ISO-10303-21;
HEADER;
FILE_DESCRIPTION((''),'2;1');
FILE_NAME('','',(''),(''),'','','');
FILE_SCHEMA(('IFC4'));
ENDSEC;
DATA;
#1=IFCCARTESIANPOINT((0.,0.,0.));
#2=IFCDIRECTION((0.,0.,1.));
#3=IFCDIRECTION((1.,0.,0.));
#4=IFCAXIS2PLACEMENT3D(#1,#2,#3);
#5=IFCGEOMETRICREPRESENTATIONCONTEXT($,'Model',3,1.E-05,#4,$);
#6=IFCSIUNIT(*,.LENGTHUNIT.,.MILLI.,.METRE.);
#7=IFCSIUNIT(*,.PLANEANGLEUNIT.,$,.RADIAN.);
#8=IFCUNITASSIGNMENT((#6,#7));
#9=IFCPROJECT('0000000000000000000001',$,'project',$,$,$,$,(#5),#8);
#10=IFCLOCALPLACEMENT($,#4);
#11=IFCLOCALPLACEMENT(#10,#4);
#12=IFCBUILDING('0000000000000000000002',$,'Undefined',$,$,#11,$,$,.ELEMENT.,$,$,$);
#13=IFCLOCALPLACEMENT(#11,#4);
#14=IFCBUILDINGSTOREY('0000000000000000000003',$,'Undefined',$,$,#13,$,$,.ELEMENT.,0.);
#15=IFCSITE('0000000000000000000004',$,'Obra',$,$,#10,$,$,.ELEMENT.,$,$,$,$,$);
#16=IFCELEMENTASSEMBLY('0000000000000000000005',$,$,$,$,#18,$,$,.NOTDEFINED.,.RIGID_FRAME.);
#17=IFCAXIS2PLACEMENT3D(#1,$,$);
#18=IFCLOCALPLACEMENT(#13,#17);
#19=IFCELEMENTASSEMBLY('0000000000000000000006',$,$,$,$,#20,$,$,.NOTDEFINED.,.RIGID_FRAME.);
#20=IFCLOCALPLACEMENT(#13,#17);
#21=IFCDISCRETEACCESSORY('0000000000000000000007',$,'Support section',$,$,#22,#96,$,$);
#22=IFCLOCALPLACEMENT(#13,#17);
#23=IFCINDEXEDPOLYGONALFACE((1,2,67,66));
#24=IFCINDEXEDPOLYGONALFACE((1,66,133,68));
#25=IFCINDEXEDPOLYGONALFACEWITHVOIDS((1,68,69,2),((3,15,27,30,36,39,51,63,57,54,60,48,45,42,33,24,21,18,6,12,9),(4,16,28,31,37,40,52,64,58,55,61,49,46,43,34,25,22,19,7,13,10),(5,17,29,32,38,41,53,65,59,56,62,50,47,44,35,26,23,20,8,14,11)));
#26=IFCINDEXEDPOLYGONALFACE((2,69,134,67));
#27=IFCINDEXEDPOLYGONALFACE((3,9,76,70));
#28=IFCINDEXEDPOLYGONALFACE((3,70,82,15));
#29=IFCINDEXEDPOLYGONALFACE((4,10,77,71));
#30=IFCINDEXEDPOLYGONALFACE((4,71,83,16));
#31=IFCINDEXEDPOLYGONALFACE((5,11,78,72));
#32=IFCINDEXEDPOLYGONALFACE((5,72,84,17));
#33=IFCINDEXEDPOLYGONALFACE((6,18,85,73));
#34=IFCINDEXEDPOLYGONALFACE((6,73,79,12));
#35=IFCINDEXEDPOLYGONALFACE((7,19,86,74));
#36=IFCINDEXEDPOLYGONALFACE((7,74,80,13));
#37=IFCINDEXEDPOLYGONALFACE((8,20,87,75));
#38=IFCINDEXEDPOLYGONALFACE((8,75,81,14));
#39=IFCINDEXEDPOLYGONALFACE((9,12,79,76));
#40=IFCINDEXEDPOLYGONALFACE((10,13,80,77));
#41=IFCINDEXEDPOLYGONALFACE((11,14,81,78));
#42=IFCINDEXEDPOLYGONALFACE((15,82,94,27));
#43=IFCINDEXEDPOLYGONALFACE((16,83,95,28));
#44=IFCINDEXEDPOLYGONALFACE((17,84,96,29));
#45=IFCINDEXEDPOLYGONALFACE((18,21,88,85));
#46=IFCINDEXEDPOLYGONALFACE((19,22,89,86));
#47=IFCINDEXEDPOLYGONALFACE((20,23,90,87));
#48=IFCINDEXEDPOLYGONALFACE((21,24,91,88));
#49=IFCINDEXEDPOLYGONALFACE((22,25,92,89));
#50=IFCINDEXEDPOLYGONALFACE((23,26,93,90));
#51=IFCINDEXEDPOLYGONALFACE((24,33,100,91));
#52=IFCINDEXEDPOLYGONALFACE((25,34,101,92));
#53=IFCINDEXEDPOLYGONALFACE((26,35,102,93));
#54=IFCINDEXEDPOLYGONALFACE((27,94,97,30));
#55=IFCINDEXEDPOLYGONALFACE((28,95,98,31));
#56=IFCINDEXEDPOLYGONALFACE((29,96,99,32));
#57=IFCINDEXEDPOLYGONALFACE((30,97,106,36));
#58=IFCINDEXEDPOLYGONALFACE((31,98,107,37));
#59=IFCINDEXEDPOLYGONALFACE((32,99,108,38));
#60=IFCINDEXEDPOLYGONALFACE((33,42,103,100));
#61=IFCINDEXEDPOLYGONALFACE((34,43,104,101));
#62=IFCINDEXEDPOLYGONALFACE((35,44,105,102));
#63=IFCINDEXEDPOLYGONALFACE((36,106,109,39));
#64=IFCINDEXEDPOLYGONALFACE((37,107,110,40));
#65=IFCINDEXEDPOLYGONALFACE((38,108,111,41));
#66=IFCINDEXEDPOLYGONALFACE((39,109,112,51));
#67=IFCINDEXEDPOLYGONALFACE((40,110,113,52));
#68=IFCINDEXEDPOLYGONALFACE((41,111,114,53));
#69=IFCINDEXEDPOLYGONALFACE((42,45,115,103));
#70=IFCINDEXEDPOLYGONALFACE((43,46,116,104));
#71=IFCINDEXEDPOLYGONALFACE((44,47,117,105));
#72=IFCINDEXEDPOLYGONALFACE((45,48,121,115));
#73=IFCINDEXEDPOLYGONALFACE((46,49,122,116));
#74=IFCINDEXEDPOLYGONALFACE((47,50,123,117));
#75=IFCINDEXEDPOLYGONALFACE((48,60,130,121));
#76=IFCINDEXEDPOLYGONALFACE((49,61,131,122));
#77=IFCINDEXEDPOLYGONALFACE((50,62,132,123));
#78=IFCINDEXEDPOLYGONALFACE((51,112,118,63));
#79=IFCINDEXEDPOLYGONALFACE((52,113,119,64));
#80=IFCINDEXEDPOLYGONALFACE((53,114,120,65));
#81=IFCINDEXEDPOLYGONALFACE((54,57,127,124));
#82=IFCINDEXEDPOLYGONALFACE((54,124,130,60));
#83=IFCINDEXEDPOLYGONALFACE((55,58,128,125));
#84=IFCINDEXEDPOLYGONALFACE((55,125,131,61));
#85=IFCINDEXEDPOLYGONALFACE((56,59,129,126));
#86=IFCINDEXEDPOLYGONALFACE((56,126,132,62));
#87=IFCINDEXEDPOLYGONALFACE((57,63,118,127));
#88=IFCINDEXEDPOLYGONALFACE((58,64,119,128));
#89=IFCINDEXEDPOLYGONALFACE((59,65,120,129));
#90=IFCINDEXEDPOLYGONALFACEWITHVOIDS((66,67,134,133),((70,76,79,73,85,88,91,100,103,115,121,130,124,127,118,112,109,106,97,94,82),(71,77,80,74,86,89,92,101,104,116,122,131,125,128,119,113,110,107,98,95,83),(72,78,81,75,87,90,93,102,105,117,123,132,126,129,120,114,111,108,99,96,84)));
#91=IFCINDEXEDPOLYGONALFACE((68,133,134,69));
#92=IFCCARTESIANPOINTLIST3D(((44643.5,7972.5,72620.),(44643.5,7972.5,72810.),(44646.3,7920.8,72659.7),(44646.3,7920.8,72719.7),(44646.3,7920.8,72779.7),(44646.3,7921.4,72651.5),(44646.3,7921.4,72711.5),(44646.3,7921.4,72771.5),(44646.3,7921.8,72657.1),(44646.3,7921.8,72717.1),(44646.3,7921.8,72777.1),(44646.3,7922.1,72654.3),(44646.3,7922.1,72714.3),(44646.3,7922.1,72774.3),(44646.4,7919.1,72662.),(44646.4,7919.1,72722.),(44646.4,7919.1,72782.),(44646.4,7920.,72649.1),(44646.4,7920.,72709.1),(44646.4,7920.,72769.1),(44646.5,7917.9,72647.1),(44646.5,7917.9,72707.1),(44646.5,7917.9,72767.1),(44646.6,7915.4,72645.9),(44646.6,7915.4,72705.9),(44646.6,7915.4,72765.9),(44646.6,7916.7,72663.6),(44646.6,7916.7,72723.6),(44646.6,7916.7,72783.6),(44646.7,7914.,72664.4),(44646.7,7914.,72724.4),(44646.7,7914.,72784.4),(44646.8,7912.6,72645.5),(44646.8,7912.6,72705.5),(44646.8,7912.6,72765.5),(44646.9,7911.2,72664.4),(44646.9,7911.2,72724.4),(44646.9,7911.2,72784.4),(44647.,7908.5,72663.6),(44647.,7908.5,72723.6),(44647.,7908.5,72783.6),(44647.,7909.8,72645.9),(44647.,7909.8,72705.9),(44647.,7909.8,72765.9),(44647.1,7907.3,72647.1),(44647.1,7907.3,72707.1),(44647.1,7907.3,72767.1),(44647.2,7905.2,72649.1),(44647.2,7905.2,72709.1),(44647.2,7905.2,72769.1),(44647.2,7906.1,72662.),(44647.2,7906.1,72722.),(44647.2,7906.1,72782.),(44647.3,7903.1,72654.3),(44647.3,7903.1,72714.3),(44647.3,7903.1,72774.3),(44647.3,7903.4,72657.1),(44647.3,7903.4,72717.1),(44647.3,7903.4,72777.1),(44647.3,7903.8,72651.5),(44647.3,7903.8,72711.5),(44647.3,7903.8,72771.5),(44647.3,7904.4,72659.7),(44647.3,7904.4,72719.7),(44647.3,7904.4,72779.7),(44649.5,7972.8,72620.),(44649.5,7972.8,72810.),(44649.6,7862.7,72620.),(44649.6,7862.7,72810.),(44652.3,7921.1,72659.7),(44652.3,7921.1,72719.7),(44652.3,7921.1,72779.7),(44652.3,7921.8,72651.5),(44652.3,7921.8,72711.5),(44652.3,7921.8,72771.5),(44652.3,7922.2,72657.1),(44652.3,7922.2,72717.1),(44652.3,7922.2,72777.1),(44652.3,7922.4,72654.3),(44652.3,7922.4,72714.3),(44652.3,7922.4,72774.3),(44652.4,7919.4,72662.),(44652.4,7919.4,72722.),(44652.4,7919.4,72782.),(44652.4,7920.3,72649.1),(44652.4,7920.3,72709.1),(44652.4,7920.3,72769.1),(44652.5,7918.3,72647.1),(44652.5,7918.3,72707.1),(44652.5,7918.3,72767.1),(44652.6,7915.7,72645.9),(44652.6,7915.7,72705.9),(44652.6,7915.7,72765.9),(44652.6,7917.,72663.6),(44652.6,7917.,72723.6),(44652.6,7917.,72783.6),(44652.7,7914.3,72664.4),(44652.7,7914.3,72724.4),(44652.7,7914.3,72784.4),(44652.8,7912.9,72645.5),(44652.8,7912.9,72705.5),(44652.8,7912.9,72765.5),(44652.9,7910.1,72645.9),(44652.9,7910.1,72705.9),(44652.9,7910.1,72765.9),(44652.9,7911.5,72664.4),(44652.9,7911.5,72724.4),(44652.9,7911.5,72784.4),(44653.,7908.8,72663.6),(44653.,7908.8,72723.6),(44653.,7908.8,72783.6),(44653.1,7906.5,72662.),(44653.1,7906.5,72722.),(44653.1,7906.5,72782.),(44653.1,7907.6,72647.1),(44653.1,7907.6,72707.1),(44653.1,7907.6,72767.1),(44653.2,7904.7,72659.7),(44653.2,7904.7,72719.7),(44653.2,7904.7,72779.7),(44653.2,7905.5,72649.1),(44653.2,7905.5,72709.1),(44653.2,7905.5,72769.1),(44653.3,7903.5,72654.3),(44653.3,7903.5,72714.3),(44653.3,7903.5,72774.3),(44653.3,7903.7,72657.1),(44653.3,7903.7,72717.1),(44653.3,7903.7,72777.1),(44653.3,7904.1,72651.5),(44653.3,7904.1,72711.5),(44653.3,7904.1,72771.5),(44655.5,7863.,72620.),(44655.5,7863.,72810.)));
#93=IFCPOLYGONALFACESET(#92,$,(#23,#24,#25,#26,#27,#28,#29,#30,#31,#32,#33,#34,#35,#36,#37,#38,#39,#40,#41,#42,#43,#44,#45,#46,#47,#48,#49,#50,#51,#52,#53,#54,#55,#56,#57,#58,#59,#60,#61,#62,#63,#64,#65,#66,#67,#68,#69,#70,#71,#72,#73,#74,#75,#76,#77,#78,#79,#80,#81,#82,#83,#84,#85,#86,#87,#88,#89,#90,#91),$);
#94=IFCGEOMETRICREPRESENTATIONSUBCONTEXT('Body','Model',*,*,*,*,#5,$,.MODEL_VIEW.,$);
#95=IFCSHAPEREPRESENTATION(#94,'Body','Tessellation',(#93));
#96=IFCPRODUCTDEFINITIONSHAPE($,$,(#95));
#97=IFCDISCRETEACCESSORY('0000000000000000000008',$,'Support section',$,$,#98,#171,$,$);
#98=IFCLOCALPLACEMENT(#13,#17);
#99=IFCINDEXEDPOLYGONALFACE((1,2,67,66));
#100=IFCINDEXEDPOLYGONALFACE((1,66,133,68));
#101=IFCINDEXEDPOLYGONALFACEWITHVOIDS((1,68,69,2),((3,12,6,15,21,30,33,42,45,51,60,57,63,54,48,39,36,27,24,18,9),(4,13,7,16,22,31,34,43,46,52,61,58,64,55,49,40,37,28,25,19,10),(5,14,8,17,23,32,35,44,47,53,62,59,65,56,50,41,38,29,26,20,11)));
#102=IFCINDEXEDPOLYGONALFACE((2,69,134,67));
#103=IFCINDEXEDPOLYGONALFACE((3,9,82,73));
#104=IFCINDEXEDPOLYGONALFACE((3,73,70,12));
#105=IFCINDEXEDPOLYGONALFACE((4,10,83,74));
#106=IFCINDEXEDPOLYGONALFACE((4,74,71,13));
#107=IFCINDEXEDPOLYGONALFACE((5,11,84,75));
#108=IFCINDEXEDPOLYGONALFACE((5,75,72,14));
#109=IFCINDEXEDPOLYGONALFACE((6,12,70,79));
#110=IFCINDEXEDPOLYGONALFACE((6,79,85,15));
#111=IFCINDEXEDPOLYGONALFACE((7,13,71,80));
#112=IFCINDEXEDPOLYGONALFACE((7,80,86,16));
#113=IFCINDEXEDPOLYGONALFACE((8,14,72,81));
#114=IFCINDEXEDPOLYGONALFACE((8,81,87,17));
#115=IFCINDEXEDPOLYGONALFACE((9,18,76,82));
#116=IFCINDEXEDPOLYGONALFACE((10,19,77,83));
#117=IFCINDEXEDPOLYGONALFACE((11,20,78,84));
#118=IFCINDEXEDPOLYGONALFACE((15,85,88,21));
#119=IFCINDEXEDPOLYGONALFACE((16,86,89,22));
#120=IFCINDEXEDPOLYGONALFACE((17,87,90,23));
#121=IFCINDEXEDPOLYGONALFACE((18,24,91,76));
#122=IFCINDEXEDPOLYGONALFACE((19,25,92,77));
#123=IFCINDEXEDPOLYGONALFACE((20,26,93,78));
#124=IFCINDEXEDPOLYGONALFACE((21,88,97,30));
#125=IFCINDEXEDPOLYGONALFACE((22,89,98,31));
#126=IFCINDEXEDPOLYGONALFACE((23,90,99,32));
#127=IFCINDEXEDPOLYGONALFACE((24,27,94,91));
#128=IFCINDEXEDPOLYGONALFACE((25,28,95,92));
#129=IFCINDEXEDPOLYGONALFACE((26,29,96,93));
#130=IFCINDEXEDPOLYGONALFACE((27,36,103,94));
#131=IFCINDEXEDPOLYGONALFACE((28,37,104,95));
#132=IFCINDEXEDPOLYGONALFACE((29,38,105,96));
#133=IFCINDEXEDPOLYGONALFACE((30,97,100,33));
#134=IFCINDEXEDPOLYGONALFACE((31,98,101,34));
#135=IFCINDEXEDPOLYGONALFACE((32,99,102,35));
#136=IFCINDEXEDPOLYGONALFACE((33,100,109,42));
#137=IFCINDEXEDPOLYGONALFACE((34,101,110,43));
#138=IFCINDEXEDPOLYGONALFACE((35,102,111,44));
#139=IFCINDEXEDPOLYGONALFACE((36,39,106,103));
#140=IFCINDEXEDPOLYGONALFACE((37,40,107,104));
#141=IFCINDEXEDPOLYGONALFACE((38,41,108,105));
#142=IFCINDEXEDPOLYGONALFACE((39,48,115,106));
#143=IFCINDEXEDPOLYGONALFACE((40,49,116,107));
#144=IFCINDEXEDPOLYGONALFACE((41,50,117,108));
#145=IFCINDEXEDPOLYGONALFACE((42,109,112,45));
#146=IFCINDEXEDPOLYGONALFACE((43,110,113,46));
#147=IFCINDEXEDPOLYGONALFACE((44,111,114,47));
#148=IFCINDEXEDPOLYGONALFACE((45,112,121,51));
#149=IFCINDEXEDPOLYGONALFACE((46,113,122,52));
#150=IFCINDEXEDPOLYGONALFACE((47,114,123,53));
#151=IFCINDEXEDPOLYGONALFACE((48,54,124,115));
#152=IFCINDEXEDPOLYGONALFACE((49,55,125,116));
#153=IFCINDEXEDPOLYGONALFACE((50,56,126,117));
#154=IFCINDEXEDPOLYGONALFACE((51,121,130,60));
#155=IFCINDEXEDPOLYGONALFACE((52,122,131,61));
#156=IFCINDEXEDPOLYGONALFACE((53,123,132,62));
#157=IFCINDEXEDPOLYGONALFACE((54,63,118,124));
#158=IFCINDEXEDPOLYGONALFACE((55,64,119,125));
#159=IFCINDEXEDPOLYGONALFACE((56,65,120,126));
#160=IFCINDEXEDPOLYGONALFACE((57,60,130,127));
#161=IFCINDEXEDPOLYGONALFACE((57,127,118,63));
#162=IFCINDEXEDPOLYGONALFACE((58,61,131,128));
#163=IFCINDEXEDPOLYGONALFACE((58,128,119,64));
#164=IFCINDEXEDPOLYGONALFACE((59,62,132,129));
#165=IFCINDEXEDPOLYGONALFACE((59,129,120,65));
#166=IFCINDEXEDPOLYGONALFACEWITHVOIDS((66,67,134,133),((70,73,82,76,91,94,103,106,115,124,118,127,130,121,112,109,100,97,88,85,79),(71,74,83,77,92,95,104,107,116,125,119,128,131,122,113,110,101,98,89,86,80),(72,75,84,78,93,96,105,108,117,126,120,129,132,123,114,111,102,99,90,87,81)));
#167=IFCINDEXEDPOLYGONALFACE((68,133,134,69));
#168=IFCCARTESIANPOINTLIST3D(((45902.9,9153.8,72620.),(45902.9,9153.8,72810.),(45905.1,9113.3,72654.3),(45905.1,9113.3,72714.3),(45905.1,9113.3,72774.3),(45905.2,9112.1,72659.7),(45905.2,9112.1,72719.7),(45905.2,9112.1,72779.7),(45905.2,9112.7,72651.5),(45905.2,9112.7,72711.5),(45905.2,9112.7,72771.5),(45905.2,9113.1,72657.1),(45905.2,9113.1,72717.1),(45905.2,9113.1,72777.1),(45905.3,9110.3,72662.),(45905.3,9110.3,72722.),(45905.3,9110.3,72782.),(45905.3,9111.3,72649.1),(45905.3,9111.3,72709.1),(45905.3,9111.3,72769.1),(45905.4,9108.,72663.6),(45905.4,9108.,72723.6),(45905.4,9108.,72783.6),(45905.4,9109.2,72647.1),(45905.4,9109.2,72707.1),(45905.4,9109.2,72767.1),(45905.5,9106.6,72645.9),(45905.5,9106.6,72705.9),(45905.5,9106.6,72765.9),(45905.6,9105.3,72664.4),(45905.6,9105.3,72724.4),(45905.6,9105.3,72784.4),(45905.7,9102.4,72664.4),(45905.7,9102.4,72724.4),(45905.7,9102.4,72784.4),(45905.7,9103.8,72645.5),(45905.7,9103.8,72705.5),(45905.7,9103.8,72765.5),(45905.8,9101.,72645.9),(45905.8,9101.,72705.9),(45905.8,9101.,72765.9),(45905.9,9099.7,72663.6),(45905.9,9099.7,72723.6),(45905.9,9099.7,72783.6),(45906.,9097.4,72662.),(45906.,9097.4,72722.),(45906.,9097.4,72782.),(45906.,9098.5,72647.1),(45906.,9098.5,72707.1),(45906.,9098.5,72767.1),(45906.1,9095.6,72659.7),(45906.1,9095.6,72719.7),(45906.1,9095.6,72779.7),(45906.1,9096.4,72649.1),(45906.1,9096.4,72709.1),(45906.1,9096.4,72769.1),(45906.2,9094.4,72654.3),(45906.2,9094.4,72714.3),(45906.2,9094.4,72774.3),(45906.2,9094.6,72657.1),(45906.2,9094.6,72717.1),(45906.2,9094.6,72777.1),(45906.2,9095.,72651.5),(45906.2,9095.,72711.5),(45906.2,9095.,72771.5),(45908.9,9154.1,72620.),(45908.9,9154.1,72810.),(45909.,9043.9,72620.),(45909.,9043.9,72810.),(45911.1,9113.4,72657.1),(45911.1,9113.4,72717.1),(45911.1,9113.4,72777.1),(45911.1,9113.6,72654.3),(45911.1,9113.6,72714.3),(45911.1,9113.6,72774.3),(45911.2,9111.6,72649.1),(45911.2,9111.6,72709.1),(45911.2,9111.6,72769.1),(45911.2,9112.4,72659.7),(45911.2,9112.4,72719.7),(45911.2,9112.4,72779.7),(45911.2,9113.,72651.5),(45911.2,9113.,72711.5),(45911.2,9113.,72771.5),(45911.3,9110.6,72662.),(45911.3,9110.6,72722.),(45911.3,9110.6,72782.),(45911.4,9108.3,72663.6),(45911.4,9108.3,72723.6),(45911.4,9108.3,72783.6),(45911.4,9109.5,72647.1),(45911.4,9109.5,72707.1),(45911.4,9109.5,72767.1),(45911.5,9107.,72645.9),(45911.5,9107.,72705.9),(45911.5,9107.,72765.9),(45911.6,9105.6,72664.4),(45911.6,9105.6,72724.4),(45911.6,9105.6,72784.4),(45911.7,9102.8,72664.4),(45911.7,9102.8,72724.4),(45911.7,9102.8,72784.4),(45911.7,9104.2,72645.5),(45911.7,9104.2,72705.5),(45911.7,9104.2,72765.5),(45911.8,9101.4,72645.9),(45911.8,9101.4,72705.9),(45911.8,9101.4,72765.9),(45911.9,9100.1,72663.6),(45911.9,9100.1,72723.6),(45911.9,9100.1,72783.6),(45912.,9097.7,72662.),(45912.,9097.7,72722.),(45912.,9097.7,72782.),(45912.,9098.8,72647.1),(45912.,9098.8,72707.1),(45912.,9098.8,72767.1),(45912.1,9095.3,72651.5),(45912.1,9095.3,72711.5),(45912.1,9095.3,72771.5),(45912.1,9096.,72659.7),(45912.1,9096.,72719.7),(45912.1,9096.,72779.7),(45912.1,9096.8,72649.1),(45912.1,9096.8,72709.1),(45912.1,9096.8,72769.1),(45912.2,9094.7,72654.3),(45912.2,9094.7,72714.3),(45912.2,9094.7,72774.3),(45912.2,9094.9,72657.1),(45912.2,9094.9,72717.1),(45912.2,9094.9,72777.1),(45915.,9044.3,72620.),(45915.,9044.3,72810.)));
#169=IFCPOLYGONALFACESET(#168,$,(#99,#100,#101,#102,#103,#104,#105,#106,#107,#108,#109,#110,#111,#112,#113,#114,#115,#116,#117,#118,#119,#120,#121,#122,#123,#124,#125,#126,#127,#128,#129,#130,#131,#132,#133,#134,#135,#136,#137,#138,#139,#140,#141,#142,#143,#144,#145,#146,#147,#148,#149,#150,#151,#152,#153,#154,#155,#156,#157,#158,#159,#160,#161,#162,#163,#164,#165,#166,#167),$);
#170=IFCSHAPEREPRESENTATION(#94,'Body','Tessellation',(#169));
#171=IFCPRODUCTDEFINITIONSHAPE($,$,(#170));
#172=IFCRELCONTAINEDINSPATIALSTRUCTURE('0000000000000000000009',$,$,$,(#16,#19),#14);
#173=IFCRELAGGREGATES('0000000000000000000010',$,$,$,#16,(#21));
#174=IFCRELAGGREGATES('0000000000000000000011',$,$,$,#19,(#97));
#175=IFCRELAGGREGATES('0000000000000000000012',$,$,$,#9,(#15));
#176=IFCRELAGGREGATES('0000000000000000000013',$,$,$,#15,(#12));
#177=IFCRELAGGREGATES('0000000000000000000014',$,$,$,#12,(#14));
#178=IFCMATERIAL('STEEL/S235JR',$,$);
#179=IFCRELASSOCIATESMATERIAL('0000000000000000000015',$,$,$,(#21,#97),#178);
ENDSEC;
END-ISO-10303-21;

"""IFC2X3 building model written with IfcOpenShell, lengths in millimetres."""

from ifc_helpers import new_model, si_unit, frame, origin_with_axes, origin_2d_with_axis, place, context, subcontext, project, spatial, rectangle, circle, extrude, source, transform, mapped, material, element, aggregate, save


model = new_model("IFC2X3")

# Units and contexts
model_context = context("Model", 3, precision=1e-05, world=origin_with_axes())
body_context = subcontext(model_context, "Body", "Model", "MODEL_VIEW")
ifc_project = project(units=[si_unit("LENGTHUNIT", "METRE", prefix="MILLI"), si_unit("PLANEANGLEUNIT", "RADIAN")], contexts=[model_context])

# Site, building, storey
site_placement = place(None, origin_with_axes())
site = spatial("IfcSite", under=ifc_project, at=site_placement, Name="Obra", CompositionType="ELEMENT")
building_placement = place(site_placement, origin_with_axes())
building = spatial("IfcBuilding", under=site, at=building_placement, Name="Undefined", CompositionType="ELEMENT")
storey_placement = place(building_placement, origin_with_axes())
storey = spatial("IfcBuildingStorey", under=building, at=storey_placement, Name="Undefined", CompositionType="ELEMENT", Elevation=0.0)

# Element assemblies
ifc_material_1 = material(Name="STEEL/S235JR")
assembly_1_placement = place(storey_placement, origin_with_axes())
assembly_1 = element("IfcElementAssembly", 1, at=assembly_1_placement, inside=storey, AssemblyPlace="NOTDEFINED", PredefinedType="RIGID_FRAME")
assembly_2_placement = place(storey_placement, origin_with_axes())
assembly_2 = element("IfcElementAssembly", 2, at=assembly_2_placement, inside=storey, AssemblyPlace="NOTDEFINED", PredefinedType="RIGID_FRAME")

# Shared definitions
shared_shape = source(origin_with_axes(), body_context, "Body", "SweptSolid", [
    extrude(circle(Radius=9.5, at=origin_2d_with_axis()), frame((0.0, -9.2, 0.0), z_axis=(0.0, 1.0, 0.0), x_axis=(1.0, 0.0, 0.0)), (0.0, 0.0, 1.0), 6.2),
])

# Discrete accessories, openings
discrete_accessory_1_placement = place(assembly_1_placement, frame((44649.5, 7917.8, 72620.0), z_axis=(0.0, 0.0, 1.0), x_axis=(-0.055152, 0.998478, 0.0)))
discrete_accessory_1 = element("IfcDiscreteAccessory", 3, at=discrete_accessory_1_placement, material=ifc_material_1, Name="Support section", context=body_context, shape_type="SweptSolid", body=[
    extrude(rectangle(XDim=6.0, YDim=110.0, at=origin_2d_with_axis()), frame((0.0, 0.0, 190.0), z_axis=(0.0, 0.0, -1.0), x_axis=(0.0, 1.0, 0.0)), (0.0, 0.0, 1.0), 190.0),
])
opening_1_placement = place(assembly_1_placement, frame((44653.1, 7963.0, 72835.0), z_axis=(0.055152, -0.998478, 0.0), x_axis=(0.0, 0.0, -1.0)))
element("IfcOpeningElement", 4, at=opening_1_placement, cuts=discrete_accessory_1, ObjectType="Opening", context=body_context, shape_type="MappedRepresentation", body=[
    mapped(shared_shape, transform((60.0, 0.0, 50.0))),
    mapped(shared_shape, transform((120.0, 0.0, 50.0))),
    mapped(shared_shape, transform((180.0, 0.0, 50.0))),
])
aggregate(assembly_1, [discrete_accessory_1])
discrete_accessory_2_placement = place(assembly_2_placement, frame((45908.9, 9099.0, 72620.0), z_axis=(0.0, 0.0, 1.0), x_axis=(0.055152, -0.998478, 0.0)))
discrete_accessory_2 = element("IfcDiscreteAccessory", 5, at=discrete_accessory_2_placement, material=ifc_material_1, Name="Support section", context=body_context, shape_type="SweptSolid", body=[
    extrude(rectangle(XDim=6.0, YDim=110.0, at=origin_2d_with_axis()), frame((0.0, 0.0, 190.0), z_axis=(0.0, 0.0, -1.0), x_axis=(0.0, 1.0, 0.0)), (0.0, 0.0, 1.0), 190.0),
])
opening_2_placement = place(assembly_2_placement, frame((45905.3, 9053.7, 72835.0), z_axis=(-0.055152, 0.998478, 0.0), x_axis=(0.0, 0.0, -1.0)))
element("IfcOpeningElement", 6, at=opening_2_placement, cuts=discrete_accessory_2, ObjectType="Opening", context=body_context, shape_type="MappedRepresentation", body=[
    mapped(shared_shape, transform((60.0, 0.0, 50.0))),
    mapped(shared_shape, transform((120.0, 0.0, 50.0))),
    mapped(shared_shape, transform((180.0, 0.0, 50.0))),
])
aggregate(assembly_2, [discrete_accessory_2])

save(model, "model.ifc")
